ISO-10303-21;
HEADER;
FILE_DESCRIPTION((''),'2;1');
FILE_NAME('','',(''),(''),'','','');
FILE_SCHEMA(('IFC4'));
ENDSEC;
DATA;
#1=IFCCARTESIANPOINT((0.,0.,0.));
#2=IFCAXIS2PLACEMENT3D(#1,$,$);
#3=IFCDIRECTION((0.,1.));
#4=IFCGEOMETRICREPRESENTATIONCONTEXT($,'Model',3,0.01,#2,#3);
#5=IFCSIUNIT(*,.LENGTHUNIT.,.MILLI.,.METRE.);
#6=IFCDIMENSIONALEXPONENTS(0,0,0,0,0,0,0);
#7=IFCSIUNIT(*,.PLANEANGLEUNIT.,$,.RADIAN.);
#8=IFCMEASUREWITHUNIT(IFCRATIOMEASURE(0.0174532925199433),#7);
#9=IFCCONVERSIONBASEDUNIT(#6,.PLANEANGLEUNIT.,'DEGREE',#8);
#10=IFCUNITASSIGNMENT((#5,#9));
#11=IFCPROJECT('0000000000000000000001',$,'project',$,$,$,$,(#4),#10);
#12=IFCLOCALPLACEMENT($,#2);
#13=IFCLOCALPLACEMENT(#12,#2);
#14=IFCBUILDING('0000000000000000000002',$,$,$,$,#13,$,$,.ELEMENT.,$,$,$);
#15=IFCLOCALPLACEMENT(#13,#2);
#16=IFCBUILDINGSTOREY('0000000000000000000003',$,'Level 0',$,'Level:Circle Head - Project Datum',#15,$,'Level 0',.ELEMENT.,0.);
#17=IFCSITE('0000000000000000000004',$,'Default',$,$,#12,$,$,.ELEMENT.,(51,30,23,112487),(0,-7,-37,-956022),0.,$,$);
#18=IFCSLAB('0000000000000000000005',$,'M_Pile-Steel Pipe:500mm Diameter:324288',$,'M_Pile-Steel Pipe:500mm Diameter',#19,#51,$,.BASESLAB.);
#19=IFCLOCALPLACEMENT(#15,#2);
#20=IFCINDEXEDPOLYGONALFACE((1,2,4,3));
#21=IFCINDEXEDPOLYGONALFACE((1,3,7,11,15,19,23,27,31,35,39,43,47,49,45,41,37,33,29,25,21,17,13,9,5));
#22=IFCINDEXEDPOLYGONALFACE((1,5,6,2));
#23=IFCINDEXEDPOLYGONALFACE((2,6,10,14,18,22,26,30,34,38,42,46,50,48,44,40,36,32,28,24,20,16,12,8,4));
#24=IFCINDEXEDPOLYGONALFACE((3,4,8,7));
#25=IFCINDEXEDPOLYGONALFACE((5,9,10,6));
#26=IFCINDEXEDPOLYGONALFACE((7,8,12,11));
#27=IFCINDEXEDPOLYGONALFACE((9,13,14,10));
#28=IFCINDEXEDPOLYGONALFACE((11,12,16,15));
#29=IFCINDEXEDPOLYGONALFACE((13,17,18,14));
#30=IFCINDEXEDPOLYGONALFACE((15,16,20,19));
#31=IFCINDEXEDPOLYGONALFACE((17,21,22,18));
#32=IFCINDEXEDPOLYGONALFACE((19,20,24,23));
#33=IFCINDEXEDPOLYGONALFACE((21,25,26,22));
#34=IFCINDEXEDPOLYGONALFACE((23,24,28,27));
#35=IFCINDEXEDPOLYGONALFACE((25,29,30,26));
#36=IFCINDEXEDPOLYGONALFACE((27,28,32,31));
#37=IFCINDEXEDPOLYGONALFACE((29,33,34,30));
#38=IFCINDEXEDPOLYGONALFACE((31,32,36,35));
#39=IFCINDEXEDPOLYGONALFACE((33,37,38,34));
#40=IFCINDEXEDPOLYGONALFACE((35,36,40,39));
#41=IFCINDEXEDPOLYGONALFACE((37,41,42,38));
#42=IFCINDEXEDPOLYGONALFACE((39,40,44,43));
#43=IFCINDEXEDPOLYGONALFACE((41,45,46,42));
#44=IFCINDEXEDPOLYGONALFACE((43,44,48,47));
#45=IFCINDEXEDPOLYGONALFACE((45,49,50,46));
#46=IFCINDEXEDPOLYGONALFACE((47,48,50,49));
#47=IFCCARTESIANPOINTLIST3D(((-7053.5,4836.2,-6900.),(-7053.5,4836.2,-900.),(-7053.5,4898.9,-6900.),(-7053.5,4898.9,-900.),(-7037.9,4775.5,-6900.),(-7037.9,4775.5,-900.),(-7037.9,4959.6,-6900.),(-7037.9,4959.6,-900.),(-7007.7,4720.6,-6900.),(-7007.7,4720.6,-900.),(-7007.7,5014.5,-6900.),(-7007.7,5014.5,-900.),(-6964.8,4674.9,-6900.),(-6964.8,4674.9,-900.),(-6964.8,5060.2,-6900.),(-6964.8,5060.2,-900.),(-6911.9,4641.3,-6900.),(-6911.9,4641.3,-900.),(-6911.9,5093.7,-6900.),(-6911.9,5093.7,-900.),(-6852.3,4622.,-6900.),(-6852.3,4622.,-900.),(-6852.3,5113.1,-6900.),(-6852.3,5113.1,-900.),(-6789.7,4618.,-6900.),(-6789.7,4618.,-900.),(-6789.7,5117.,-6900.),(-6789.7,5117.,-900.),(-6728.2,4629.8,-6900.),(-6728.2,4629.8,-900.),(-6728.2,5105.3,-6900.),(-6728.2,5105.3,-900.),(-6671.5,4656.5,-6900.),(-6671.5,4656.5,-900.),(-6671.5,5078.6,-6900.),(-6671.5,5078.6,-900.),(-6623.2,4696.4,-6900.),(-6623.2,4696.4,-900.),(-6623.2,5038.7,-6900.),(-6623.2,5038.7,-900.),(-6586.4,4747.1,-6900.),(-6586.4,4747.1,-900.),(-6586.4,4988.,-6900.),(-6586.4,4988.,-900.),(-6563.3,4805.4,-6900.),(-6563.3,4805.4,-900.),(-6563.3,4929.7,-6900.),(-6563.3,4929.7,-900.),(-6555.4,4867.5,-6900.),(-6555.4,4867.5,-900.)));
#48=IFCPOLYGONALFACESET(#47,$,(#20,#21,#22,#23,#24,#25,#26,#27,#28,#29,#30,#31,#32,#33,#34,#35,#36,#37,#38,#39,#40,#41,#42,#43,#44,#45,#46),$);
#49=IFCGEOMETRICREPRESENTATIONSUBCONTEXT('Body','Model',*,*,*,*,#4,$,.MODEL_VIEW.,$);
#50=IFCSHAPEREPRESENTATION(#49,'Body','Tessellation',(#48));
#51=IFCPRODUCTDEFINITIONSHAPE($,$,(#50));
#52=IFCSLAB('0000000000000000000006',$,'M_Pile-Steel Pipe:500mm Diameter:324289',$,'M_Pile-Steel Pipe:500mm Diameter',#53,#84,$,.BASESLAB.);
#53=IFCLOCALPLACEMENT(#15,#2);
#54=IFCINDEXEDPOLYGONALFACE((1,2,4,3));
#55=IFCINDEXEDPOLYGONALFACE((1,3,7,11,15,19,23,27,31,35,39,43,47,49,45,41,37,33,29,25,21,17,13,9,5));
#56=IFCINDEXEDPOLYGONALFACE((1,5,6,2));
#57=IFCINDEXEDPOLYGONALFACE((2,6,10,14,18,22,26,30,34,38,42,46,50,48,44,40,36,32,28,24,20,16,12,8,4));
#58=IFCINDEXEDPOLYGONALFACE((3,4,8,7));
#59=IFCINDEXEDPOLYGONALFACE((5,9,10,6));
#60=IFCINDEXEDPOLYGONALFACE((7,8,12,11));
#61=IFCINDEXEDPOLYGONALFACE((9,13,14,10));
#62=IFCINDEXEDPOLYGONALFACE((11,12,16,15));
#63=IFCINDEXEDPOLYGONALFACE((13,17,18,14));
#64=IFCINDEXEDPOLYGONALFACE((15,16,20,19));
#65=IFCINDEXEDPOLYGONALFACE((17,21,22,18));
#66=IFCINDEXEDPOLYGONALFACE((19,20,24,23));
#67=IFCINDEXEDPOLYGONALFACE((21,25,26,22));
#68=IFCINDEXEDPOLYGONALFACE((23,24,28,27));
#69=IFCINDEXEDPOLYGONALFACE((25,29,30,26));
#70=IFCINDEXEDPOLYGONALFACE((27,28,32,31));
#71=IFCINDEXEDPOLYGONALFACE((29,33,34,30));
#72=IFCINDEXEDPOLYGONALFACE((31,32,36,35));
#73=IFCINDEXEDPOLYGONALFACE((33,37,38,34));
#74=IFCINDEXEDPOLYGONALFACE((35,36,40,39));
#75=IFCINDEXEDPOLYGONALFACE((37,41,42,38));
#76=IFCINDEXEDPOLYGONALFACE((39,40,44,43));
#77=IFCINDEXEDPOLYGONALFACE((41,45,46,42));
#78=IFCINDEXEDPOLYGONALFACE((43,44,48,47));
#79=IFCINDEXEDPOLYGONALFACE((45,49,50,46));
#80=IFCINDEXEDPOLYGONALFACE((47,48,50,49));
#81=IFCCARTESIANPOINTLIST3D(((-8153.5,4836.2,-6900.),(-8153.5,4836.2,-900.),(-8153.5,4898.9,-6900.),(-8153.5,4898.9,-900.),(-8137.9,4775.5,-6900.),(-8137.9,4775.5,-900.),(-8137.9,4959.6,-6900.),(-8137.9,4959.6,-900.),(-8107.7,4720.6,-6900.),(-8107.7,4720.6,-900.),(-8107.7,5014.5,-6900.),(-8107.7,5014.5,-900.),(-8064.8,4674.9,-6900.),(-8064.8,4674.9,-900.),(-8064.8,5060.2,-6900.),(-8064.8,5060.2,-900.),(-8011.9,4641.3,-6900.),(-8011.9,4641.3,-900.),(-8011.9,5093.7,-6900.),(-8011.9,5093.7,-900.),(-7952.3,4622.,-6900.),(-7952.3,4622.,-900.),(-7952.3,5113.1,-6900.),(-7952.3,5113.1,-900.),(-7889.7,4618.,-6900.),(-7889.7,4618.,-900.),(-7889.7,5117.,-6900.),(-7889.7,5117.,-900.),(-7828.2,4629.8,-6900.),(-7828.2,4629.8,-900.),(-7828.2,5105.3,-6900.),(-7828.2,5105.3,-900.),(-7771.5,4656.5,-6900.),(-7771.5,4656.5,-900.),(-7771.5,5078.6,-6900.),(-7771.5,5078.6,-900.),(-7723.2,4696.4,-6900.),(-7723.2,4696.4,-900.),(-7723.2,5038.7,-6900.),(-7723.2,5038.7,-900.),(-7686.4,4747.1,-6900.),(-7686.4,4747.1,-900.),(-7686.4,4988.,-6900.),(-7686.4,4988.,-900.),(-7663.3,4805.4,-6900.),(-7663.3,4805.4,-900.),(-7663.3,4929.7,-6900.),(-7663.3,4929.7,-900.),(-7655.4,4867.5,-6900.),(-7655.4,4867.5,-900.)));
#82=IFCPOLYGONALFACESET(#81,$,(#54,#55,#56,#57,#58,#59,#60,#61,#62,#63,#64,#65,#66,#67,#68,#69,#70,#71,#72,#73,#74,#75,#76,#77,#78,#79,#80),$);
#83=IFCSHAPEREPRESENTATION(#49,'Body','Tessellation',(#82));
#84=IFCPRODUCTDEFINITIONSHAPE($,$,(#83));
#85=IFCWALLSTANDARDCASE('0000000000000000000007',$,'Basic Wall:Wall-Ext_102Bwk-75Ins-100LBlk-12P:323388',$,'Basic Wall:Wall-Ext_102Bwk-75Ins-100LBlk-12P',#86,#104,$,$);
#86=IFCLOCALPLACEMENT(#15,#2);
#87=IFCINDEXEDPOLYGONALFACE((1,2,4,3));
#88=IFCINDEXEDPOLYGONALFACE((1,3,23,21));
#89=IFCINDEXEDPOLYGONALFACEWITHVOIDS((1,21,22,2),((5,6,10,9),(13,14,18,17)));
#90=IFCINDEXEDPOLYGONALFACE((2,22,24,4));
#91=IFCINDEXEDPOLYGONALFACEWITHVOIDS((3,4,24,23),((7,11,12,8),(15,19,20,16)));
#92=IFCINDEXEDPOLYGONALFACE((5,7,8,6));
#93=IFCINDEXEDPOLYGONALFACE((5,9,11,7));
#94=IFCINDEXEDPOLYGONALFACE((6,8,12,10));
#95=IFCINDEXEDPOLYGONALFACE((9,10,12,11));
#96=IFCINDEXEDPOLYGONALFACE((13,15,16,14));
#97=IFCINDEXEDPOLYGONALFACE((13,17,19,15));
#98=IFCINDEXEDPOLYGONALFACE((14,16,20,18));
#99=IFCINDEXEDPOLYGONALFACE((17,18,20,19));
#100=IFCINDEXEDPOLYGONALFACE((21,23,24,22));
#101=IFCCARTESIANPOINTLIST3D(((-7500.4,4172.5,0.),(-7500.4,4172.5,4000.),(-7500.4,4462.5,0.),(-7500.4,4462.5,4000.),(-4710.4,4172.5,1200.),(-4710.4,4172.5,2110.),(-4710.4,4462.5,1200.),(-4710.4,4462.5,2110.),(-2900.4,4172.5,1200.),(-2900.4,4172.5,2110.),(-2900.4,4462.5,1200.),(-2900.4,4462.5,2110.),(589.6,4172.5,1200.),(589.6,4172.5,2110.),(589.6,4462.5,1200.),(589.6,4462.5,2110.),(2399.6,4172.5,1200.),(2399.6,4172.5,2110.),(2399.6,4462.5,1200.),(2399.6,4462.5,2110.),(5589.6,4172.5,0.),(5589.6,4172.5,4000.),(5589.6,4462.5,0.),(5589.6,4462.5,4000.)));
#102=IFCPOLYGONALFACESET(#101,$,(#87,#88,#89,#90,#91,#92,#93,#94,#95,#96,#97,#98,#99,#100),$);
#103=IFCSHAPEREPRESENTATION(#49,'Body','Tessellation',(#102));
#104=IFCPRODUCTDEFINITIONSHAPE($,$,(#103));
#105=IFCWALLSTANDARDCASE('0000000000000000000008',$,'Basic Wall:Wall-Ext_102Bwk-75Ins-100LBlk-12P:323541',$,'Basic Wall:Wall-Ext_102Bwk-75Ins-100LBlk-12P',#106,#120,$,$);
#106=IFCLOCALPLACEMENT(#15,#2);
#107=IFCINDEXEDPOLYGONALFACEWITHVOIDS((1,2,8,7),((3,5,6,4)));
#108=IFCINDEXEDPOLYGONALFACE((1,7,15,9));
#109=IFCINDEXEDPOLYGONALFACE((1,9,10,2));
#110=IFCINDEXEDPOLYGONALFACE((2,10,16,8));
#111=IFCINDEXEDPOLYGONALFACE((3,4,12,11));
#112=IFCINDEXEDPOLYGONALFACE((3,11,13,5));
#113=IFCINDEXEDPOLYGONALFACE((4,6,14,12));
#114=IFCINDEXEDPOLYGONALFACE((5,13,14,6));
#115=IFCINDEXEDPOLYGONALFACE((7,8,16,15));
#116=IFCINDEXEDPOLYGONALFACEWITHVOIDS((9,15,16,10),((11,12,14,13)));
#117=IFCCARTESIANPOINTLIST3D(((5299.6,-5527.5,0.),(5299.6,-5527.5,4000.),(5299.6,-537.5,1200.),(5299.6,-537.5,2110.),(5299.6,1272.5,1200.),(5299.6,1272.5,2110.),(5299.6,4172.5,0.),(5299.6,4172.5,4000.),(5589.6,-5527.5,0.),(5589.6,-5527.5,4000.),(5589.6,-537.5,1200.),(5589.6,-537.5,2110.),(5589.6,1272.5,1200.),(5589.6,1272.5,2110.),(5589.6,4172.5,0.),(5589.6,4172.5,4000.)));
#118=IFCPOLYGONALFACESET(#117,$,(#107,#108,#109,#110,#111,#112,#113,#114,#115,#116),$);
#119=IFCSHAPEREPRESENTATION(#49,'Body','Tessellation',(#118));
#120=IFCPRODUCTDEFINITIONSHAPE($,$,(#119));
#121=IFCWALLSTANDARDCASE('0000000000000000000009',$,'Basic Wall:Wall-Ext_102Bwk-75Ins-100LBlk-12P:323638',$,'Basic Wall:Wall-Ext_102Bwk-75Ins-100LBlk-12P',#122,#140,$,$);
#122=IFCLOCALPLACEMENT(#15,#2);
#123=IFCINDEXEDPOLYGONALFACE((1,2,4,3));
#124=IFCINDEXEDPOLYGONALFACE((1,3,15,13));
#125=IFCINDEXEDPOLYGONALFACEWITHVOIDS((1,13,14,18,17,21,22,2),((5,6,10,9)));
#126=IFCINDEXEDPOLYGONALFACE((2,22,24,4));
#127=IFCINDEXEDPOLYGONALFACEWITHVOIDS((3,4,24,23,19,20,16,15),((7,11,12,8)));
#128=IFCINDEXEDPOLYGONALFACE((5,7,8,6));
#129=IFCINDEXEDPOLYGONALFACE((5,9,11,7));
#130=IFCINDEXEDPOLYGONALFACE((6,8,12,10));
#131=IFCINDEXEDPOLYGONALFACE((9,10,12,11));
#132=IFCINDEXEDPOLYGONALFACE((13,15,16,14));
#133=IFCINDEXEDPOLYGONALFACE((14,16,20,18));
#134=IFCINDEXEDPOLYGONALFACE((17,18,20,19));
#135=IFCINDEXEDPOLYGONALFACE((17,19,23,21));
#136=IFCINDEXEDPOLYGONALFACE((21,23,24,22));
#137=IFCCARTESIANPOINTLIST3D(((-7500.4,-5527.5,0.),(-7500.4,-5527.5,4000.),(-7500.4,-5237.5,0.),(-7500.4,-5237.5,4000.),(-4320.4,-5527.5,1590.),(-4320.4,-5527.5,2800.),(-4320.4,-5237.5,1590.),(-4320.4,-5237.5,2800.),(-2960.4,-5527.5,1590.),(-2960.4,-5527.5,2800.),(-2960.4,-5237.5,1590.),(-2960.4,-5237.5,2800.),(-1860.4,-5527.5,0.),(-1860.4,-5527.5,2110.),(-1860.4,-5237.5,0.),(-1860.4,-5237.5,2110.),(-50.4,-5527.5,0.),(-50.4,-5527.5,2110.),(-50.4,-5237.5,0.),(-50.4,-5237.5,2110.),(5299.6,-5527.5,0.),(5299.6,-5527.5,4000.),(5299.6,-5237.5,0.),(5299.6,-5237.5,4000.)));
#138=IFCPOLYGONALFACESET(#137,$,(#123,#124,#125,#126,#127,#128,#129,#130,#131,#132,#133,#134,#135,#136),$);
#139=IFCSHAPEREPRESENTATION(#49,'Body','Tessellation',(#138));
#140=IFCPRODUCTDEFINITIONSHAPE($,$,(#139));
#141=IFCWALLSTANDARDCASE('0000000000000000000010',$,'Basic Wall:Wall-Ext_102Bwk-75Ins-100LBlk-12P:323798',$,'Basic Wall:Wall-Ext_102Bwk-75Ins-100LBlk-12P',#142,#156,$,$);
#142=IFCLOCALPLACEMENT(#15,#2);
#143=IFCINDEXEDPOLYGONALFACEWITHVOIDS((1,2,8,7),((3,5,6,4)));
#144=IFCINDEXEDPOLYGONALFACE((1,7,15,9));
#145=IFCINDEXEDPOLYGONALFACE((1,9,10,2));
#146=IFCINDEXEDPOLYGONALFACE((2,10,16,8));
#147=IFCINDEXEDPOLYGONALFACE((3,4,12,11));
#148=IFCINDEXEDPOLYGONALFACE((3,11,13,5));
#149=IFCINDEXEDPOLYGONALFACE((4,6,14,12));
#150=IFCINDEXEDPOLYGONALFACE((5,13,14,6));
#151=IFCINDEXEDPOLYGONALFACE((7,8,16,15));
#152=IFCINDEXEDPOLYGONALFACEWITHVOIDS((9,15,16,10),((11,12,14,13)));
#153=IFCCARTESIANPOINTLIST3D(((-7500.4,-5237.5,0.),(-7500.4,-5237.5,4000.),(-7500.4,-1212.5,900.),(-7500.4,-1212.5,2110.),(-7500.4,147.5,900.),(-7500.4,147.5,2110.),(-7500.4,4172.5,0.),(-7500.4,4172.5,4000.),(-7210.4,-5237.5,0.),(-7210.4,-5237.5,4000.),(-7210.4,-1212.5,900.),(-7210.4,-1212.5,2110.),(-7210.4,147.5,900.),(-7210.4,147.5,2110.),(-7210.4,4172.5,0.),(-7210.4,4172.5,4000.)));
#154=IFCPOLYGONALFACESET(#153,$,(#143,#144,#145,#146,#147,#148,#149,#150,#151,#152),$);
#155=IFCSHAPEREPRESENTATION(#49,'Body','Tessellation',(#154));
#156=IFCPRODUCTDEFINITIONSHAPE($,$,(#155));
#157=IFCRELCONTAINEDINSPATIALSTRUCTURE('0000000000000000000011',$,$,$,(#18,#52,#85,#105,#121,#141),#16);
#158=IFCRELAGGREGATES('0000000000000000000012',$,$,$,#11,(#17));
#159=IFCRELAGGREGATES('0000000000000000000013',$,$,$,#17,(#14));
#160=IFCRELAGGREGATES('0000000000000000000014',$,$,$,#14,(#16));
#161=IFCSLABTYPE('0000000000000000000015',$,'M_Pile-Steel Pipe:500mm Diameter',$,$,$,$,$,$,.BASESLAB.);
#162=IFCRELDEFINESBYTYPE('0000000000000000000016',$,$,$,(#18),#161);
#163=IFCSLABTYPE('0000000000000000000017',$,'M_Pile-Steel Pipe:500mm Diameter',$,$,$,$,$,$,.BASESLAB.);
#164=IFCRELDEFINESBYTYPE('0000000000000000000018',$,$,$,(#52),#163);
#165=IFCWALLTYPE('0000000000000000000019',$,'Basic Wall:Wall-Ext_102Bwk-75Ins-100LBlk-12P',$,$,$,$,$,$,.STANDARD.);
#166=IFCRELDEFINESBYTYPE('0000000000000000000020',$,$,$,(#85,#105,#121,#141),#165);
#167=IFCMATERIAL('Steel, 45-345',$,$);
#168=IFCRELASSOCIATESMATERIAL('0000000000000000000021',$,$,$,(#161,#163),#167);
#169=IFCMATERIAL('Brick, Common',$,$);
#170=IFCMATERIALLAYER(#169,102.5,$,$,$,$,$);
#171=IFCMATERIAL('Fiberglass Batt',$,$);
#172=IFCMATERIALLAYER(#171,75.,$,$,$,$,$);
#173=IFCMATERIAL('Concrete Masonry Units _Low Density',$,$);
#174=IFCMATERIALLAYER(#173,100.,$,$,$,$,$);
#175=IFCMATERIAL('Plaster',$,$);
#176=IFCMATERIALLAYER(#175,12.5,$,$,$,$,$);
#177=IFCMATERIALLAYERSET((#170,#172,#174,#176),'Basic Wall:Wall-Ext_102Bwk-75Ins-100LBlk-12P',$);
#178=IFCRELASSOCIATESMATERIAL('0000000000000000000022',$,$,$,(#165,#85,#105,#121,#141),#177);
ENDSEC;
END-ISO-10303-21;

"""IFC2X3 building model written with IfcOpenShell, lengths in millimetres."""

from ifc_helpers import new_model, entity, si_unit, converted_unit, direction, frame, frame_2d, origin, place, context, subcontext, project, spatial, rectangle, circle, extrude, material, layer, layer_set, layer_usage, type_object, element, save


model = new_model("IFC2X3")

# Units and contexts
model_context = context("Model", 3, precision=0.01, world=origin(), true_north=direction((0.0, 1.0)))
body_context = subcontext(model_context, "Body", "Model", "MODEL_VIEW")
ifc_project = project(units=[si_unit("LENGTHUNIT", "METRE", prefix="MILLI"), converted_unit("PLANEANGLEUNIT", "DEGREE", entity("IfcRatioMeasure", 0.0174532925199433), si_unit("PLANEANGLEUNIT", "RADIAN"), dimensions=[0, 0, 0, 0, 0, 0, 0])], contexts=[model_context])

# Site, building, storey
site_placement = place(None, origin())
site = spatial("IfcSite", under=ifc_project, at=site_placement, Name="Default", CompositionType="ELEMENT", RefLatitude=(51, 30, 23, 112487), RefLongitude=(0, -7, -37, -956022), RefElevation=0.0)
building_placement = place(site_placement, origin())
building = spatial("IfcBuilding", under=site, at=building_placement, CompositionType="ELEMENT")
storey_placement = place(building_placement, origin())
storey = spatial("IfcBuildingStorey", under=building, at=storey_placement, Name="Level 0", ObjectType="Level:Circle Head - Project Datum", LongName="Level 0", CompositionType="ELEMENT", Elevation=0.0)

# Slabs
ifc_material_1 = material(Name="Steel, 45-345")
slab_type_1 = type_object("IfcSlabType", Name="M_Pile-Steel Pipe:500mm Diameter", PredefinedType="BASESLAB", material=ifc_material_1)
slab_1_placement = place(storey_placement, origin())
element("IfcSlab", 1, at=slab_1_placement, inside=storey, type_object=slab_type_1, Name="M_Pile-Steel Pipe:500mm Diameter:324288", ObjectType="M_Pile-Steel Pipe:500mm Diameter", PredefinedType="BASESLAB", context=body_context, shape_type="SweptSolid", body=[
    extrude(circle(Radius=250.0, at=frame_2d((0.0, 0.0), x_axis=(1.0, 0.0))), frame((-6805.4, 4867.5, -6900.0)), (0.0, 0.0, 1.0), 6000.0),
])
slab_type_2 = type_object("IfcSlabType", Name="M_Pile-Steel Pipe:500mm Diameter", PredefinedType="BASESLAB", material=ifc_material_1)
slab_2_placement = place(storey_placement, origin())
element("IfcSlab", 2, at=slab_2_placement, inside=storey, type_object=slab_type_2, Name="M_Pile-Steel Pipe:500mm Diameter:324289", ObjectType="M_Pile-Steel Pipe:500mm Diameter", PredefinedType="BASESLAB", context=body_context, shape_type="SweptSolid", body=[
    extrude(circle(Radius=250.0, at=frame_2d((0.0, 0.0), x_axis=(1.0, 0.0))), frame((-7905.4, 4867.5, -6900.0)), (0.0, 0.0, 1.0), 6000.0),
])

# Wall, openings
ifc_material_2 = material(Name="Brick, Common")
ifc_layer_1 = layer(ifc_material_2, 102.5)
ifc_material_3 = material(Name="Fiberglass Batt")
ifc_layer_2 = layer(ifc_material_3, 75.0)
ifc_material_4 = material(Name="Concrete Masonry Units _Low Density")
ifc_layer_3 = layer(ifc_material_4, 100.0)
ifc_material_5 = material(Name="Plaster")
ifc_layer_4 = layer(ifc_material_5, 12.5)
ifc_layer_set_1 = layer_set([ifc_layer_1, ifc_layer_2, ifc_layer_3, ifc_layer_4], Name="Basic Wall:Wall-Ext_102Bwk-75Ins-100LBlk-12P")
ifc_layer_usage_1 = layer_usage(ifc_layer_set_1, "AXIS2", "NEGATIVE", 145.0)
wall_type = type_object("IfcWallType", Name="Basic Wall:Wall-Ext_102Bwk-75Ins-100LBlk-12P", PredefinedType="STANDARD", material=ifc_layer_set_1)
wall_1_placement = place(storey_placement, frame((-7500.4, 4317.5, 0.0)))
wall_1 = element("IfcWallStandardCase", 3, at=wall_1_placement, inside=storey, type_object=wall_type, material=ifc_layer_usage_1, Name="Basic Wall:Wall-Ext_102Bwk-75Ins-100LBlk-12P:323388", ObjectType="Basic Wall:Wall-Ext_102Bwk-75Ins-100LBlk-12P", context=body_context, shape_type="SweptSolid", body=[
    extrude(rectangle(XDim=13090.0, YDim=290.0, at=frame_2d((6545.0, 0.0), x_axis=(-1.0, 0.0))), origin(), (0.0, 0.0, 1.0), 4000.0),
])
opening_1_placement = place(wall_1_placement, frame((2790.0, -145.0, 1200.0)))
element("IfcOpeningElement", 4, at=opening_1_placement, cuts=wall_1, ObjectType="Opening", context=body_context, shape_type="SweptSolid", body=[
    extrude(rectangle(XDim=910.0, YDim=1810.0, at=frame_2d((455.0, 905.0), x_axis=(-1.0, 0.0))), frame((0.0, 0.0, 0.0), z_axis=(0.0, 1.0, 0.0), x_axis=(0.0, 0.0, 1.0)), (0.0, 0.0, 1.0), 290.0),
])
opening_2_placement = place(wall_1_placement, frame((8090.0, -145.0, 1200.0)))
element("IfcOpeningElement", 5, at=opening_2_placement, cuts=wall_1, ObjectType="Opening", context=body_context, shape_type="SweptSolid", body=[
    extrude(rectangle(XDim=910.0, YDim=1810.0, at=frame_2d((455.0, 905.0), x_axis=(-1.0, 0.0))), frame((0.0, 0.0, 0.0), z_axis=(0.0, 1.0, 0.0), x_axis=(0.0, 0.0, 1.0)), (0.0, 0.0, 1.0), 290.0),
])

# Wall, opening
ifc_layer_usage_2 = layer_usage(ifc_layer_set_1, "AXIS2", "NEGATIVE", 145.0)
wall_2_placement = place(storey_placement, frame((5444.6, 4172.5, 0.0), z_axis=(0.0, 0.0, 1.0), x_axis=(0.0, -1.0, 0.0)))
wall_2 = element("IfcWallStandardCase", 6, at=wall_2_placement, inside=storey, type_object=wall_type, material=ifc_layer_usage_2, Name="Basic Wall:Wall-Ext_102Bwk-75Ins-100LBlk-12P:323541", ObjectType="Basic Wall:Wall-Ext_102Bwk-75Ins-100LBlk-12P", context=body_context, shape_type="SweptSolid", body=[
    extrude(rectangle(XDim=9700.0, YDim=290.0, at=frame_2d((4850.0, 0.0), x_axis=(-1.0, 0.0))), origin(), (0.0, 0.0, 1.0), 4000.0),
])
opening_3_placement = place(wall_2_placement, frame((2900.0, -145.0, 1200.0)))
element("IfcOpeningElement", 7, at=opening_3_placement, cuts=wall_2, ObjectType="Opening", context=body_context, shape_type="SweptSolid", body=[
    extrude(rectangle(XDim=910.0, YDim=1810.0, at=frame_2d((455.0, 905.0), x_axis=(-1.0, 0.0))), frame((0.0, 0.0, 0.0), z_axis=(0.0, 1.0, 0.0), x_axis=(0.0, 0.0, 1.0)), (0.0, 0.0, 1.0), 290.0),
])

# Wall, openings
ifc_layer_usage_3 = layer_usage(ifc_layer_set_1, "AXIS2", "NEGATIVE", 145.0)
wall_3_placement = place(storey_placement, frame((5299.6, -5382.5, 0.0), z_axis=(0.0, 0.0, 1.0), x_axis=(-1.0, 0.0, 0.0)))
wall_3 = element("IfcWallStandardCase", 8, at=wall_3_placement, inside=storey, type_object=wall_type, material=ifc_layer_usage_3, Name="Basic Wall:Wall-Ext_102Bwk-75Ins-100LBlk-12P:323638", ObjectType="Basic Wall:Wall-Ext_102Bwk-75Ins-100LBlk-12P", context=body_context, shape_type="SweptSolid", body=[
    extrude(rectangle(XDim=12800.0, YDim=290.0, at=frame_2d((6400.0, 0.0), x_axis=(-1.0, 0.0))), origin(), (0.0, 0.0, 1.0), 4000.0),
])
opening_4_placement = place(wall_3_placement, frame((7160.0, 145.0, 0.0)))
element("IfcOpeningElement", 9, at=opening_4_placement, cuts=wall_3, ObjectType="Opening", context=body_context, shape_type="SweptSolid", body=[
    extrude(rectangle(XDim=2110.0, YDim=1810.0, at=frame_2d((1055.0, 905.0), x_axis=(-1.0, 0.0))), frame((0.0, 0.0, 0.0), z_axis=(0.0, -1.0, 0.0), x_axis=(0.0, 0.0, 1.0)), (0.0, 0.0, 1.0), 290.0),
])
opening_5_placement = place(wall_3_placement, frame((8260.0, -145.0, 1590.0)))
element("IfcOpeningElement", 10, at=opening_5_placement, cuts=wall_3, ObjectType="Opening", context=body_context, shape_type="SweptSolid", body=[
    extrude(rectangle(XDim=1210.0, YDim=1360.0, at=frame_2d((605.0, 680.0), x_axis=(-1.0, 0.0))), frame((0.0, 0.0, 0.0), z_axis=(0.0, 1.0, 0.0), x_axis=(0.0, 0.0, 1.0)), (0.0, 0.0, 1.0), 290.0),
])

# Wall, opening
ifc_layer_usage_4 = layer_usage(ifc_layer_set_1, "AXIS2", "NEGATIVE", 145.0)
wall_4_placement = place(storey_placement, frame((-7355.4, -5237.5, 0.0), z_axis=(0.0, 0.0, 1.0), x_axis=(0.0, 1.0, 0.0)))
wall_4 = element("IfcWallStandardCase", 11, at=wall_4_placement, inside=storey, type_object=wall_type, material=ifc_layer_usage_4, Name="Basic Wall:Wall-Ext_102Bwk-75Ins-100LBlk-12P:323798", ObjectType="Basic Wall:Wall-Ext_102Bwk-75Ins-100LBlk-12P", context=body_context, shape_type="SweptSolid", body=[
    extrude(rectangle(XDim=9410.0, YDim=290.0, at=frame_2d((4705.0, 0.0), x_axis=(-1.0, 0.0))), origin(), (0.0, 0.0, 1.0), 4000.0),
])
opening_6_placement = place(wall_4_placement, frame((5385.0, 145.0, 900.0)))
element("IfcOpeningElement", 12, at=opening_6_placement, cuts=wall_4, ObjectType="Opening", context=body_context, shape_type="SweptSolid", body=[
    extrude(rectangle(XDim=1210.0, YDim=1360.0, at=frame_2d((605.0, 680.0), x_axis=(-1.0, 0.0))), frame((0.0, 0.0, 0.0), z_axis=(0.0, -1.0, 0.0), x_axis=(0.0, 0.0, 1.0)), (0.0, 0.0, 1.0), 290.0),
])

save(model, "model.ifc")
